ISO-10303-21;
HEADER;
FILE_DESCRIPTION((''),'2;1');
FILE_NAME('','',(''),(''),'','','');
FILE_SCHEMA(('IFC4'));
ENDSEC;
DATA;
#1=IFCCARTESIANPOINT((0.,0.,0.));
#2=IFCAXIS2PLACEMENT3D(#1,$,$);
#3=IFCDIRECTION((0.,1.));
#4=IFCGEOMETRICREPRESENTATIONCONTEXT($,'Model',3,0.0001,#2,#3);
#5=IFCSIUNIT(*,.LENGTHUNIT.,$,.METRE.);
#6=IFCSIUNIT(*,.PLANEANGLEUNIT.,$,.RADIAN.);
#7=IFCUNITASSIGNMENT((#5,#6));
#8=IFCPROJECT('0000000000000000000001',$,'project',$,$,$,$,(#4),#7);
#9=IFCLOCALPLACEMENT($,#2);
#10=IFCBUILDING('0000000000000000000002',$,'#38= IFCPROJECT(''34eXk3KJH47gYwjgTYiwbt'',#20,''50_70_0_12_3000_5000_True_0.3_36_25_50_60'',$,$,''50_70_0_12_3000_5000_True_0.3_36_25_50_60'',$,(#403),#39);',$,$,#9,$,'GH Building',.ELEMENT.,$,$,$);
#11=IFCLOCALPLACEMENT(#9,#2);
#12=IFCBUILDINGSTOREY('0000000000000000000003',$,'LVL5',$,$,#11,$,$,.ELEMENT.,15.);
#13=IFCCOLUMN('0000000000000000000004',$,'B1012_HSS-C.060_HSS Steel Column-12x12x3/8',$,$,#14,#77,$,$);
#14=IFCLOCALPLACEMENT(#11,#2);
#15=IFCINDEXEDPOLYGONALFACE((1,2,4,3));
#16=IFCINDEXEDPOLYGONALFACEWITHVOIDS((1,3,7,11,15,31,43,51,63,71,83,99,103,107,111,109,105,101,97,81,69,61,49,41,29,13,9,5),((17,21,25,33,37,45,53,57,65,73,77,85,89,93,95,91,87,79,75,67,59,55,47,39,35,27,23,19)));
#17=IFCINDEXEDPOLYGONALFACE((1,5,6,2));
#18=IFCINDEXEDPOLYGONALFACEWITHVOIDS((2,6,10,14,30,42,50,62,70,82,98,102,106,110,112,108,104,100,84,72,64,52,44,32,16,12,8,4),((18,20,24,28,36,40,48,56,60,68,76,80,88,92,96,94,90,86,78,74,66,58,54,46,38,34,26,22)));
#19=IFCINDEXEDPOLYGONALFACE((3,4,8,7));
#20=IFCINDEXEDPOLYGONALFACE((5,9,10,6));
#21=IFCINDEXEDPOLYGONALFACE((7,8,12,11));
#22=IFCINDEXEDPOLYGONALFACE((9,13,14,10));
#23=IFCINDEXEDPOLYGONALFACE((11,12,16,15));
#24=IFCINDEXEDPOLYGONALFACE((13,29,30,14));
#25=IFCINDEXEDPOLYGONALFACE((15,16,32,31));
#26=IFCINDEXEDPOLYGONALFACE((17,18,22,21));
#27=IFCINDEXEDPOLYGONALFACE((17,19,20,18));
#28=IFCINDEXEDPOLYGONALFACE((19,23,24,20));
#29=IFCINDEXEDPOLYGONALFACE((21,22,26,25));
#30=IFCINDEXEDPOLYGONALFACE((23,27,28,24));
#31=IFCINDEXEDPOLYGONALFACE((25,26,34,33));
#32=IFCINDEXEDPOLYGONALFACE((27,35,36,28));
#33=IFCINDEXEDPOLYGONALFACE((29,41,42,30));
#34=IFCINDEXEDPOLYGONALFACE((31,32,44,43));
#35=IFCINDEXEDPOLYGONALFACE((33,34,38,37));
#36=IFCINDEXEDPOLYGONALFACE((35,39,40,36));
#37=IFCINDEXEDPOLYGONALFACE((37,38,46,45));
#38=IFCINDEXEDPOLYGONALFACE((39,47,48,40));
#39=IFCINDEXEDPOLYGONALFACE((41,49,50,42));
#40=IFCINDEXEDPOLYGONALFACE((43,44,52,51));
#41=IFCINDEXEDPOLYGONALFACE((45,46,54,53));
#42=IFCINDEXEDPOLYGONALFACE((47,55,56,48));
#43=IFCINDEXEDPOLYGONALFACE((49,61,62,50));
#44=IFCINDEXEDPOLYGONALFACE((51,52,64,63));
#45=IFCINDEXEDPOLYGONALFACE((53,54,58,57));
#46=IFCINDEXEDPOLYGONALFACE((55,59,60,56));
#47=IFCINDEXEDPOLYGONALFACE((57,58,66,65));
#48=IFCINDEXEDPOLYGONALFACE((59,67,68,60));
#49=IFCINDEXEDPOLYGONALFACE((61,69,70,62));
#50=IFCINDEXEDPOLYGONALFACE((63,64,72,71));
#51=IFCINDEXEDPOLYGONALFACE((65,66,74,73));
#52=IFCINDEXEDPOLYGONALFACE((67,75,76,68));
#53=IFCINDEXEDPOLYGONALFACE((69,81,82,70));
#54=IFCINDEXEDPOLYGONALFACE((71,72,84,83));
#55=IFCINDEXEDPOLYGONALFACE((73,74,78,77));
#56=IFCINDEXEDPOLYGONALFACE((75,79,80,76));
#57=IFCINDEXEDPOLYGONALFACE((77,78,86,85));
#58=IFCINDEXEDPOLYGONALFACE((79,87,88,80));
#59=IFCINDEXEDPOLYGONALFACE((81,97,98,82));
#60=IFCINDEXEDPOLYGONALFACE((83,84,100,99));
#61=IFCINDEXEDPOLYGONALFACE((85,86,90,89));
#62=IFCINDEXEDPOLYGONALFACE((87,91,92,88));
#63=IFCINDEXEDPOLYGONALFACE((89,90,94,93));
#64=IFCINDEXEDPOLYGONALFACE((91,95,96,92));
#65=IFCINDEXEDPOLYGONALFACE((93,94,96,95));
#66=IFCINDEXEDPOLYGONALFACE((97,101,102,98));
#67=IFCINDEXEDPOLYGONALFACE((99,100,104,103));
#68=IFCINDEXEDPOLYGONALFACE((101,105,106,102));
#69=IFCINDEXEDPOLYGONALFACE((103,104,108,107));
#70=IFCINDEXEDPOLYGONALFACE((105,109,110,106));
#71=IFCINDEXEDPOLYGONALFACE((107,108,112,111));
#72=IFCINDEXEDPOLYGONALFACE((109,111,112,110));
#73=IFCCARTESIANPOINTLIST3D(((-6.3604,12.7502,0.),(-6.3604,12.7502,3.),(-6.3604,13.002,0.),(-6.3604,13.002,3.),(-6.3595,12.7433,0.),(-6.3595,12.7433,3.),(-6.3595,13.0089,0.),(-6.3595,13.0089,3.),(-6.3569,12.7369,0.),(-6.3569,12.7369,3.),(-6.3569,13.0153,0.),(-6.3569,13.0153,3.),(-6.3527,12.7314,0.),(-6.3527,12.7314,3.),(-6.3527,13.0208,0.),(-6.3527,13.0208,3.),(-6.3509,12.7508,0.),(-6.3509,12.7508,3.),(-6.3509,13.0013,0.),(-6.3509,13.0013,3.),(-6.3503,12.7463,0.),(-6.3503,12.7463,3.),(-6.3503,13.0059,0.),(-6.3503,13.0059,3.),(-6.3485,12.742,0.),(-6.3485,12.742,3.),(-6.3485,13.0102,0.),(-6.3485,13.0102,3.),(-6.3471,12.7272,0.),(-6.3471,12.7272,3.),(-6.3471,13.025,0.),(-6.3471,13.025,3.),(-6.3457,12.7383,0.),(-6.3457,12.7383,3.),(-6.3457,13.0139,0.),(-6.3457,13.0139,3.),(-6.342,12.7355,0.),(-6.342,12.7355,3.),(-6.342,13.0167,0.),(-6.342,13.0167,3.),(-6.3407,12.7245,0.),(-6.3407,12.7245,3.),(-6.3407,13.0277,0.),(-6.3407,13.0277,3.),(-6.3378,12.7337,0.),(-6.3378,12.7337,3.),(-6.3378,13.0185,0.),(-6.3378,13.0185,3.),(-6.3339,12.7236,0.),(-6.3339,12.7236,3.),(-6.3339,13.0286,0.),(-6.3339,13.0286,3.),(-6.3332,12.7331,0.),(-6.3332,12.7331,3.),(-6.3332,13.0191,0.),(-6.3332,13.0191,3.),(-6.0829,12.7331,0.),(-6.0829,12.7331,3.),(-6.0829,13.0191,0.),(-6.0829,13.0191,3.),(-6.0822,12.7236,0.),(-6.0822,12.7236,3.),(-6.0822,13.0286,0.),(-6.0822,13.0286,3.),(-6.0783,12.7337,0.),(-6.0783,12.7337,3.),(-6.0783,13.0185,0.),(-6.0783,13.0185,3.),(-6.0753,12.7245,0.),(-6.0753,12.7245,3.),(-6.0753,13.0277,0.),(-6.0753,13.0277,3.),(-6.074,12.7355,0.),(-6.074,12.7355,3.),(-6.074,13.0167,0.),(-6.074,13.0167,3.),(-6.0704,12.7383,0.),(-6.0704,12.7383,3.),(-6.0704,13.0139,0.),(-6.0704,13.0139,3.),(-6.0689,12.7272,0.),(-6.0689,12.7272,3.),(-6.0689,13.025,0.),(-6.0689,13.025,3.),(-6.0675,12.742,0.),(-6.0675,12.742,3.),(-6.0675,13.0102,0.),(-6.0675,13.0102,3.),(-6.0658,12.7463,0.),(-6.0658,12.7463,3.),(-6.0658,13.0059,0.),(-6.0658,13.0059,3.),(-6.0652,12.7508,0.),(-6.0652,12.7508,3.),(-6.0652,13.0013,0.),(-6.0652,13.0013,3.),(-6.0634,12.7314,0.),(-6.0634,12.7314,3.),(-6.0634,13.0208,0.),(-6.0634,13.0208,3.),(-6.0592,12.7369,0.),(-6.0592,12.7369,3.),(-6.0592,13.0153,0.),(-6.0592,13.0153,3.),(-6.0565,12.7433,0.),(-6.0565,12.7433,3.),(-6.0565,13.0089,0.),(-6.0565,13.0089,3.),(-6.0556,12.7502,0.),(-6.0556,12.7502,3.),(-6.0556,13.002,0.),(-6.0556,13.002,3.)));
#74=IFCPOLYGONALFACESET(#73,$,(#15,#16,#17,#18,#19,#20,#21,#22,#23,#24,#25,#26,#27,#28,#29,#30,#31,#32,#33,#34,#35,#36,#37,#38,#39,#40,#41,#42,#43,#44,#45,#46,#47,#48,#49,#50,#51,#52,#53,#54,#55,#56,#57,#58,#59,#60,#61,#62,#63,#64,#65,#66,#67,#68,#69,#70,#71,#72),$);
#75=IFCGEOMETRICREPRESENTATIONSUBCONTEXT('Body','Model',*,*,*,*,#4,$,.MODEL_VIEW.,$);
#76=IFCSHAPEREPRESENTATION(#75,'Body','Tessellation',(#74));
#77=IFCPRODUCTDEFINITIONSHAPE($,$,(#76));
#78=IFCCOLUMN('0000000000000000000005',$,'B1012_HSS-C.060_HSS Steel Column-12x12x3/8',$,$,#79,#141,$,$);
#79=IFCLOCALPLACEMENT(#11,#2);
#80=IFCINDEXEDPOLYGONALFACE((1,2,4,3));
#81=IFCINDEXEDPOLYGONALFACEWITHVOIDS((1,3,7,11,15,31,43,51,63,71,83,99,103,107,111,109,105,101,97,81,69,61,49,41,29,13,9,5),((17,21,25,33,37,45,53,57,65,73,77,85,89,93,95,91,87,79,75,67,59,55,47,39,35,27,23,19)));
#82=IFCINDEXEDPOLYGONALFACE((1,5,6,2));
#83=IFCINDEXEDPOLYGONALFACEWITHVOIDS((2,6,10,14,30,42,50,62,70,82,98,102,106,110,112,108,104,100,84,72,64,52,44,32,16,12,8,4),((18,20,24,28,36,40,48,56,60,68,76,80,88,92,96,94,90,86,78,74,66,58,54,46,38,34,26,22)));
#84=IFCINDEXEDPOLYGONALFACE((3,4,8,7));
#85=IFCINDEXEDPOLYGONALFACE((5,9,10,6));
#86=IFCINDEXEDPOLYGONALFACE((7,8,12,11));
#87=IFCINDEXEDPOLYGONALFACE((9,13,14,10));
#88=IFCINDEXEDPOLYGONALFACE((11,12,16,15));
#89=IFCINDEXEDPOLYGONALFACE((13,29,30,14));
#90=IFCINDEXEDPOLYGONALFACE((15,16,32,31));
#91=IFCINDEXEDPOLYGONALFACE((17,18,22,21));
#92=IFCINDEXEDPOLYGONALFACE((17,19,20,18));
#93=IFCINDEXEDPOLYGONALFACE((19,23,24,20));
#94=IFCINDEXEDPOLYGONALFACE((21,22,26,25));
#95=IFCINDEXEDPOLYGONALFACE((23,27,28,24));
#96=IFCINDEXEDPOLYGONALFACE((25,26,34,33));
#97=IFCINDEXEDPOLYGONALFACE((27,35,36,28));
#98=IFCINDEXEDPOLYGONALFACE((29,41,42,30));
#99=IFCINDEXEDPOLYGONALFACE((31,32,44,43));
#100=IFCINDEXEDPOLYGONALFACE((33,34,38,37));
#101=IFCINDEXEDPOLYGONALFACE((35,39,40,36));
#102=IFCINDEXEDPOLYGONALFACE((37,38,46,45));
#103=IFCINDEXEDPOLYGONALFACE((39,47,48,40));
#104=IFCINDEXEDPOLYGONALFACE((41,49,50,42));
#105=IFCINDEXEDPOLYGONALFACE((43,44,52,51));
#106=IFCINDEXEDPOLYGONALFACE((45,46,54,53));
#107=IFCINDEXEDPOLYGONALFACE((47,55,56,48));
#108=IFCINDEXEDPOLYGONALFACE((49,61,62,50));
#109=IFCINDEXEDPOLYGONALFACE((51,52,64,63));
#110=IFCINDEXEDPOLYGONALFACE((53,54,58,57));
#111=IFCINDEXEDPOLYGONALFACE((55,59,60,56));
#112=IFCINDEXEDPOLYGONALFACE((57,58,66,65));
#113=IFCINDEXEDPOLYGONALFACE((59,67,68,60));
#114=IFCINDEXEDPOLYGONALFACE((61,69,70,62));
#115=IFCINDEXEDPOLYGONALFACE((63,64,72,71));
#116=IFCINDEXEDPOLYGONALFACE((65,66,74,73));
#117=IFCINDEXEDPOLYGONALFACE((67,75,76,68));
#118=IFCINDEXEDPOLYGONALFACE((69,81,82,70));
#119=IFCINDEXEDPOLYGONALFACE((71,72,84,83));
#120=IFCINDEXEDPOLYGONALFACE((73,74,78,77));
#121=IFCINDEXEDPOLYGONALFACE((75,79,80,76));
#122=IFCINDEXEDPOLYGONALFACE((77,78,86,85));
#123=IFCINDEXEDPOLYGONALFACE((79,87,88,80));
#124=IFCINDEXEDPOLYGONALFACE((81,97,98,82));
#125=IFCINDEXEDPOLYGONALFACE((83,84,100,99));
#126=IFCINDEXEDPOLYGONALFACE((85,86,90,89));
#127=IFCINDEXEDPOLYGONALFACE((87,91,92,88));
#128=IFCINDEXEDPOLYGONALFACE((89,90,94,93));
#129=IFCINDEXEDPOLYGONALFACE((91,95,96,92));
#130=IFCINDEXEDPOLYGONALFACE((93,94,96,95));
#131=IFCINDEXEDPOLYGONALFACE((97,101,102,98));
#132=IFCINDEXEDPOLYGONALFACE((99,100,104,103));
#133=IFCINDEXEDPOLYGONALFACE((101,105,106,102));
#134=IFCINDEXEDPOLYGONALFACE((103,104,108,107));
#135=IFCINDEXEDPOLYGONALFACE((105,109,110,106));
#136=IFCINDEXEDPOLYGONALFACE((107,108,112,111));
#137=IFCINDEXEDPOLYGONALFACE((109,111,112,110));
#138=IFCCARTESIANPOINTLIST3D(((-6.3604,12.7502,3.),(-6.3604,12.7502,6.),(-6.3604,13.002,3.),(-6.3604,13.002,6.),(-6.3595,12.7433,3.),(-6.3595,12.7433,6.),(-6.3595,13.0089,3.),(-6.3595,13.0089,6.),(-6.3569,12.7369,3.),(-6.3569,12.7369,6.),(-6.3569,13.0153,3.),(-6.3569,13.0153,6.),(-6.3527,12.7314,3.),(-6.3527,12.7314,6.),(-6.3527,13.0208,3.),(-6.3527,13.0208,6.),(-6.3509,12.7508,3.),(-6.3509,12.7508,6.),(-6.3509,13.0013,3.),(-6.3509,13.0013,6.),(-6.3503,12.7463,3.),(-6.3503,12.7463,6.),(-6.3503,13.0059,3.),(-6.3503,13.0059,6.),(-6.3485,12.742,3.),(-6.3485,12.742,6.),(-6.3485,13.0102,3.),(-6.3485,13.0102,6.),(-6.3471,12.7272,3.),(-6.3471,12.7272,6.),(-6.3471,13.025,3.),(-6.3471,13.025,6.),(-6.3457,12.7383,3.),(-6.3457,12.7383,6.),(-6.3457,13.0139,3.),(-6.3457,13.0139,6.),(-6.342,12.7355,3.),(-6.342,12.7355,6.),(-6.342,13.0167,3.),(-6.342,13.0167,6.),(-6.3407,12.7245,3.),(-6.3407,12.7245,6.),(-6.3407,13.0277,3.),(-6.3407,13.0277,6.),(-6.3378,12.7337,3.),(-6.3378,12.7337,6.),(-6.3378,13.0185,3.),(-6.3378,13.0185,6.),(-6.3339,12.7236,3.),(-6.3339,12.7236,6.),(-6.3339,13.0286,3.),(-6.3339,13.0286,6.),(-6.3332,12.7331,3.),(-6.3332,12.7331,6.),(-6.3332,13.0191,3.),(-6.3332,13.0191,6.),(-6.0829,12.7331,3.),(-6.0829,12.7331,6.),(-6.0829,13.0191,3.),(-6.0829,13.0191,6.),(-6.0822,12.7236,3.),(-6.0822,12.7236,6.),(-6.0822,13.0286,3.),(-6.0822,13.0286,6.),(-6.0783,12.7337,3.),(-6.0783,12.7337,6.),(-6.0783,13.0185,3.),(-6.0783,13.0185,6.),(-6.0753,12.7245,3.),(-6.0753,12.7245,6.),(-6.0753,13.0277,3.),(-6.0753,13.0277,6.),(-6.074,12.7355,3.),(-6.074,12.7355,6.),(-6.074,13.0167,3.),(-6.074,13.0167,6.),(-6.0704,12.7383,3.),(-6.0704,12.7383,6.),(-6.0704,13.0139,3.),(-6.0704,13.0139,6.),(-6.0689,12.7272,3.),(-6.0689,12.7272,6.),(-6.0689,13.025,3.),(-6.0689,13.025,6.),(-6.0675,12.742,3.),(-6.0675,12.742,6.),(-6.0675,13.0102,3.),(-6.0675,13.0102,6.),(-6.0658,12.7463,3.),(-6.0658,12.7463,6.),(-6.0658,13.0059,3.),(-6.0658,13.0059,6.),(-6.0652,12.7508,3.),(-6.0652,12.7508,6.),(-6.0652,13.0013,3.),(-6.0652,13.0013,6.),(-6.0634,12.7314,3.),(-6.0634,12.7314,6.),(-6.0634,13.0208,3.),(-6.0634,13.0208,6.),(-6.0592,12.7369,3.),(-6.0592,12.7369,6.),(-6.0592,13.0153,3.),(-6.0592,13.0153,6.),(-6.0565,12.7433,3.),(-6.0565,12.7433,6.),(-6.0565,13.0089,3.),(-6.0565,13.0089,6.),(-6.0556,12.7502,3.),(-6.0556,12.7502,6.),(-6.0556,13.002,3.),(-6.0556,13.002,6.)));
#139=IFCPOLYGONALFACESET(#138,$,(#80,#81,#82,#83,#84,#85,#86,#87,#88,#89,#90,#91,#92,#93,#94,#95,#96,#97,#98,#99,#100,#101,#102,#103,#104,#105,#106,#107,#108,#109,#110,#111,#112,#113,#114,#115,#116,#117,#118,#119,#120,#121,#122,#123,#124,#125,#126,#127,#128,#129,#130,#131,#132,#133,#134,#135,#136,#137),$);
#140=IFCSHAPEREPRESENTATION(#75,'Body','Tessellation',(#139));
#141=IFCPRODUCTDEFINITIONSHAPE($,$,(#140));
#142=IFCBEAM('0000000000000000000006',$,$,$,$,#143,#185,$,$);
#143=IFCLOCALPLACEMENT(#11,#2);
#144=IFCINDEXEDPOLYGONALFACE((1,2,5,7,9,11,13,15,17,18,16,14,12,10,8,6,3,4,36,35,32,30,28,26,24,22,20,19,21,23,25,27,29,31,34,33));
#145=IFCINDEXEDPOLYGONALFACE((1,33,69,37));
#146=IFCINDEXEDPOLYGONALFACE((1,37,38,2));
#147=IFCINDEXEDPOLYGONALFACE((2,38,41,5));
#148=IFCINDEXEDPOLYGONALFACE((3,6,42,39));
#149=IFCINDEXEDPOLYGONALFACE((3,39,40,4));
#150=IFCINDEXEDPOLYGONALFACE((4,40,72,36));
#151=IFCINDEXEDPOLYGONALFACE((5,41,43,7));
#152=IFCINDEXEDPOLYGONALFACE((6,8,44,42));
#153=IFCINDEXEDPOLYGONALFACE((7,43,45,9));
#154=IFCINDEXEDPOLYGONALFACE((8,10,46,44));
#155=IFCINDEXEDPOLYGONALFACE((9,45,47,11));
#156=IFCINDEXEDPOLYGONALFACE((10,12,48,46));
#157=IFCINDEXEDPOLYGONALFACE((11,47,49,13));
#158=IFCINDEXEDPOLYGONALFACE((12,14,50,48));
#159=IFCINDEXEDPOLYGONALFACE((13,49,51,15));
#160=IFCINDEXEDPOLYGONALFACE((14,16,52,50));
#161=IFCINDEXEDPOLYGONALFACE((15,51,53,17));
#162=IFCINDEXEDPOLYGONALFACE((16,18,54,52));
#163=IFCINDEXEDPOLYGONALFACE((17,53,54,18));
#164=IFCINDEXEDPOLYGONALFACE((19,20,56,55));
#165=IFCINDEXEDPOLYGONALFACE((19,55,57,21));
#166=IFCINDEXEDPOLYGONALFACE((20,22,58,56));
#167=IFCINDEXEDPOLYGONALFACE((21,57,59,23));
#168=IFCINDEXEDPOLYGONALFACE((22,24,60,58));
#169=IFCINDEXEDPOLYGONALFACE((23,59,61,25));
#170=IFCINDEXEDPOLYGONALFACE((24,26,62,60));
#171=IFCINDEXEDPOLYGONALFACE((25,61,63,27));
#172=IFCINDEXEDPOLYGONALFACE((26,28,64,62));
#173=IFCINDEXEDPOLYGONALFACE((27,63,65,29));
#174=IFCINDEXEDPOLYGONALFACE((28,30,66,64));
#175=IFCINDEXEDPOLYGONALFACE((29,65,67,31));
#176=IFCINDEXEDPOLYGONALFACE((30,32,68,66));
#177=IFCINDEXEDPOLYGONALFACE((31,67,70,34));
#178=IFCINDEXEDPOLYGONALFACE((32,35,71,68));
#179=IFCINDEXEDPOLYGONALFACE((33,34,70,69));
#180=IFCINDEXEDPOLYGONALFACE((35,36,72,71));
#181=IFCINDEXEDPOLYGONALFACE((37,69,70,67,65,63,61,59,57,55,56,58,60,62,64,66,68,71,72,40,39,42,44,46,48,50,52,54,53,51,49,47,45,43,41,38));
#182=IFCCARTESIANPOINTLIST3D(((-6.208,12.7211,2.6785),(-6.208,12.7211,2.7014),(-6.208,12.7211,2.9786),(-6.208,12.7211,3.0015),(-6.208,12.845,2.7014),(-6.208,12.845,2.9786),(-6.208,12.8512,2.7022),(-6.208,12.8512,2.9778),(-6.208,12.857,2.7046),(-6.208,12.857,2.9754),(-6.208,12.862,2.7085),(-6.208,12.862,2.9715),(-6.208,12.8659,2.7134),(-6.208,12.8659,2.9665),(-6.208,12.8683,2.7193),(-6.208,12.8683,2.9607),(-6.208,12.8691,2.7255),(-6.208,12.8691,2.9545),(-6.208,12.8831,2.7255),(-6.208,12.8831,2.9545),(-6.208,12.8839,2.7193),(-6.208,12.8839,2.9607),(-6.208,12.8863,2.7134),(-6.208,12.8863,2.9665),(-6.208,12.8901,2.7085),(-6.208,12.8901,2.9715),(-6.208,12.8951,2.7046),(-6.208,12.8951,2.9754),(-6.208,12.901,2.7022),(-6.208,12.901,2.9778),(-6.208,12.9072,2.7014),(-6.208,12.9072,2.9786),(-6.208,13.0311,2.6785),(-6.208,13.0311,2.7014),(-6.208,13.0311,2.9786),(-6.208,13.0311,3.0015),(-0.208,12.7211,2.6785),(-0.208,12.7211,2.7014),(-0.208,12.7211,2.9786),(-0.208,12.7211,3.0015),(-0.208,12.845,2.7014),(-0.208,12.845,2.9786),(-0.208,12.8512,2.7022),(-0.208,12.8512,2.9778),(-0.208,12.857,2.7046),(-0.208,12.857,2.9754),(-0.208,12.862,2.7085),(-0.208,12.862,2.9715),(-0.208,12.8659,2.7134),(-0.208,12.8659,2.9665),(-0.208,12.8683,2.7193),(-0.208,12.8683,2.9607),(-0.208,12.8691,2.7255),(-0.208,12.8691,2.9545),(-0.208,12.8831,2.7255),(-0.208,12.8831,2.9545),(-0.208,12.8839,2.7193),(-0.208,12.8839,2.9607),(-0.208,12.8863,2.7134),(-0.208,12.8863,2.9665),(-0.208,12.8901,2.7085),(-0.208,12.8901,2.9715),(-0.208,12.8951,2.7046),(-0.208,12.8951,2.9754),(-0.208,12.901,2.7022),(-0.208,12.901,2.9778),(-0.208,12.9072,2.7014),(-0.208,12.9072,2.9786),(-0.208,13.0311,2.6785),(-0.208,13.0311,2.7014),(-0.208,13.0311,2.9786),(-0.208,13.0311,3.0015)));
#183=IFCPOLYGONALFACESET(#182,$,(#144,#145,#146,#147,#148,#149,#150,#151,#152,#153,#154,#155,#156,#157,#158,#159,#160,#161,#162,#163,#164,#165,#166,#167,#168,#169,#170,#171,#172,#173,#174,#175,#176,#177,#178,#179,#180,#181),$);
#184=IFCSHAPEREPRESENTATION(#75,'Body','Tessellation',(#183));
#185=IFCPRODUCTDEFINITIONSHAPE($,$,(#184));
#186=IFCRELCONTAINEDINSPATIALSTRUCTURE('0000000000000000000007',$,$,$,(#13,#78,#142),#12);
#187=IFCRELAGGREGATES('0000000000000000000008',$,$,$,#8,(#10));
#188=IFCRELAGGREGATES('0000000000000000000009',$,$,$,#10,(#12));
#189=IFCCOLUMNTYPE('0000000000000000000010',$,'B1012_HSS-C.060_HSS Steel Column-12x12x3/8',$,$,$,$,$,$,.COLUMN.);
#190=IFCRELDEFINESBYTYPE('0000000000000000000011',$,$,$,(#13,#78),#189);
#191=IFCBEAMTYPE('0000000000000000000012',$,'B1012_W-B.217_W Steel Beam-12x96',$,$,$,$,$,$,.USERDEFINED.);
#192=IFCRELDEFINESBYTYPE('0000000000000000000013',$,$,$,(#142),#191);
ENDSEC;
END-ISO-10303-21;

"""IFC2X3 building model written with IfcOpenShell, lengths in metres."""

from ifc_helpers import new_model, si_unit, direction, frame, origin, origin_2d, place, context, subcontext, project, spatial, hollow_rectangle, i_section, extrude, type_object, element, save


model = new_model("IFC2X3")

# Units and contexts
model_context = context("Model", 3, precision=0.0001, world=origin(), true_north=direction((0.0, 1.0)))
body_context = subcontext(model_context, "Body", "Model", "MODEL_VIEW")
ifc_project = project(units=[si_unit("LENGTHUNIT", "METRE"), si_unit("PLANEANGLEUNIT", "RADIAN")], contexts=[model_context])

# Building, storey
building_placement = place(None, origin())
building = spatial("IfcBuilding", under=ifc_project, at=building_placement, Name="#38= IFCPROJECT('34eXk3KJH47gYwjgTYiwbt',#20,'50_70_0_12_3000_5000_True_0.3_36_25_50_60',$,$,'50_70_0_12_3000_5000_True_0.3_36_25_50_60',$,(#403),#39);", LongName="GH Building", CompositionType="ELEMENT")
storey_placement = place(building_placement, origin())
storey = spatial("IfcBuildingStorey", under=building, at=storey_placement, Name="LVL5", CompositionType="ELEMENT", Elevation=15.0)

# Columns
column_type = type_object("IfcColumnType", Name="B1012_HSS-C.060_HSS Steel Column-12x12x3/8", PredefinedType="COLUMN")
for number, where, z_axis, x_axis, name in (
    (1, (-6.208, 12.8761, 3.0), (0.0, 0.0, -1.0), (-1.0, 0.0, 0.0), "B1012_HSS-C.060_HSS Steel Column-12x12x3/8"),
    (2, (-6.208, 12.8761, 6.0), (0.0, 0.0, -1.0), (-1.0, 0.0, 0.0), "B1012_HSS-C.060_HSS Steel Column-12x12x3/8"),
):
    element("IfcColumn", number, at=place(storey_placement, frame(where, z_axis=z_axis, x_axis=x_axis)), inside=storey, type_object=column_type, Name=name, context=body_context, shape_type="SweptSolid", body=[
        extrude(hollow_rectangle(XDim=0.3048, YDim=0.305, WallThickness=0.0095, InnerFilletRadius=0.0177, OuterFilletRadius=0.0266, at=origin_2d()), origin(), (0.0, 0.0, 1.0), 3.0),
    ])

# Beam
beam_type = type_object("IfcBeamType", Name="B1012_W-B.217_W Steel Beam-12x96", PredefinedType="USERDEFINED")
for number, where, z_axis, x_axis in (
    (3, (-6.208, 12.8761, 2.84), (1.0, 0.0, 0.0), (0.0, 1.0, 0.0)),
):
    element("IfcBeam", number, at=place(storey_placement, frame(where, z_axis=z_axis, x_axis=x_axis)), inside=storey, type_object=beam_type, context=body_context, shape_type="SweptSolid", body=[
        extrude(i_section(OverallWidth=0.31, OverallDepth=0.323, WebThickness=0.014, FlangeThickness=0.0229, FilletRadius=0.0241, at=origin_2d()), origin(), (0.0, 0.0, 1.0), 6.0),
    ])

save(model, "model.ifc")
